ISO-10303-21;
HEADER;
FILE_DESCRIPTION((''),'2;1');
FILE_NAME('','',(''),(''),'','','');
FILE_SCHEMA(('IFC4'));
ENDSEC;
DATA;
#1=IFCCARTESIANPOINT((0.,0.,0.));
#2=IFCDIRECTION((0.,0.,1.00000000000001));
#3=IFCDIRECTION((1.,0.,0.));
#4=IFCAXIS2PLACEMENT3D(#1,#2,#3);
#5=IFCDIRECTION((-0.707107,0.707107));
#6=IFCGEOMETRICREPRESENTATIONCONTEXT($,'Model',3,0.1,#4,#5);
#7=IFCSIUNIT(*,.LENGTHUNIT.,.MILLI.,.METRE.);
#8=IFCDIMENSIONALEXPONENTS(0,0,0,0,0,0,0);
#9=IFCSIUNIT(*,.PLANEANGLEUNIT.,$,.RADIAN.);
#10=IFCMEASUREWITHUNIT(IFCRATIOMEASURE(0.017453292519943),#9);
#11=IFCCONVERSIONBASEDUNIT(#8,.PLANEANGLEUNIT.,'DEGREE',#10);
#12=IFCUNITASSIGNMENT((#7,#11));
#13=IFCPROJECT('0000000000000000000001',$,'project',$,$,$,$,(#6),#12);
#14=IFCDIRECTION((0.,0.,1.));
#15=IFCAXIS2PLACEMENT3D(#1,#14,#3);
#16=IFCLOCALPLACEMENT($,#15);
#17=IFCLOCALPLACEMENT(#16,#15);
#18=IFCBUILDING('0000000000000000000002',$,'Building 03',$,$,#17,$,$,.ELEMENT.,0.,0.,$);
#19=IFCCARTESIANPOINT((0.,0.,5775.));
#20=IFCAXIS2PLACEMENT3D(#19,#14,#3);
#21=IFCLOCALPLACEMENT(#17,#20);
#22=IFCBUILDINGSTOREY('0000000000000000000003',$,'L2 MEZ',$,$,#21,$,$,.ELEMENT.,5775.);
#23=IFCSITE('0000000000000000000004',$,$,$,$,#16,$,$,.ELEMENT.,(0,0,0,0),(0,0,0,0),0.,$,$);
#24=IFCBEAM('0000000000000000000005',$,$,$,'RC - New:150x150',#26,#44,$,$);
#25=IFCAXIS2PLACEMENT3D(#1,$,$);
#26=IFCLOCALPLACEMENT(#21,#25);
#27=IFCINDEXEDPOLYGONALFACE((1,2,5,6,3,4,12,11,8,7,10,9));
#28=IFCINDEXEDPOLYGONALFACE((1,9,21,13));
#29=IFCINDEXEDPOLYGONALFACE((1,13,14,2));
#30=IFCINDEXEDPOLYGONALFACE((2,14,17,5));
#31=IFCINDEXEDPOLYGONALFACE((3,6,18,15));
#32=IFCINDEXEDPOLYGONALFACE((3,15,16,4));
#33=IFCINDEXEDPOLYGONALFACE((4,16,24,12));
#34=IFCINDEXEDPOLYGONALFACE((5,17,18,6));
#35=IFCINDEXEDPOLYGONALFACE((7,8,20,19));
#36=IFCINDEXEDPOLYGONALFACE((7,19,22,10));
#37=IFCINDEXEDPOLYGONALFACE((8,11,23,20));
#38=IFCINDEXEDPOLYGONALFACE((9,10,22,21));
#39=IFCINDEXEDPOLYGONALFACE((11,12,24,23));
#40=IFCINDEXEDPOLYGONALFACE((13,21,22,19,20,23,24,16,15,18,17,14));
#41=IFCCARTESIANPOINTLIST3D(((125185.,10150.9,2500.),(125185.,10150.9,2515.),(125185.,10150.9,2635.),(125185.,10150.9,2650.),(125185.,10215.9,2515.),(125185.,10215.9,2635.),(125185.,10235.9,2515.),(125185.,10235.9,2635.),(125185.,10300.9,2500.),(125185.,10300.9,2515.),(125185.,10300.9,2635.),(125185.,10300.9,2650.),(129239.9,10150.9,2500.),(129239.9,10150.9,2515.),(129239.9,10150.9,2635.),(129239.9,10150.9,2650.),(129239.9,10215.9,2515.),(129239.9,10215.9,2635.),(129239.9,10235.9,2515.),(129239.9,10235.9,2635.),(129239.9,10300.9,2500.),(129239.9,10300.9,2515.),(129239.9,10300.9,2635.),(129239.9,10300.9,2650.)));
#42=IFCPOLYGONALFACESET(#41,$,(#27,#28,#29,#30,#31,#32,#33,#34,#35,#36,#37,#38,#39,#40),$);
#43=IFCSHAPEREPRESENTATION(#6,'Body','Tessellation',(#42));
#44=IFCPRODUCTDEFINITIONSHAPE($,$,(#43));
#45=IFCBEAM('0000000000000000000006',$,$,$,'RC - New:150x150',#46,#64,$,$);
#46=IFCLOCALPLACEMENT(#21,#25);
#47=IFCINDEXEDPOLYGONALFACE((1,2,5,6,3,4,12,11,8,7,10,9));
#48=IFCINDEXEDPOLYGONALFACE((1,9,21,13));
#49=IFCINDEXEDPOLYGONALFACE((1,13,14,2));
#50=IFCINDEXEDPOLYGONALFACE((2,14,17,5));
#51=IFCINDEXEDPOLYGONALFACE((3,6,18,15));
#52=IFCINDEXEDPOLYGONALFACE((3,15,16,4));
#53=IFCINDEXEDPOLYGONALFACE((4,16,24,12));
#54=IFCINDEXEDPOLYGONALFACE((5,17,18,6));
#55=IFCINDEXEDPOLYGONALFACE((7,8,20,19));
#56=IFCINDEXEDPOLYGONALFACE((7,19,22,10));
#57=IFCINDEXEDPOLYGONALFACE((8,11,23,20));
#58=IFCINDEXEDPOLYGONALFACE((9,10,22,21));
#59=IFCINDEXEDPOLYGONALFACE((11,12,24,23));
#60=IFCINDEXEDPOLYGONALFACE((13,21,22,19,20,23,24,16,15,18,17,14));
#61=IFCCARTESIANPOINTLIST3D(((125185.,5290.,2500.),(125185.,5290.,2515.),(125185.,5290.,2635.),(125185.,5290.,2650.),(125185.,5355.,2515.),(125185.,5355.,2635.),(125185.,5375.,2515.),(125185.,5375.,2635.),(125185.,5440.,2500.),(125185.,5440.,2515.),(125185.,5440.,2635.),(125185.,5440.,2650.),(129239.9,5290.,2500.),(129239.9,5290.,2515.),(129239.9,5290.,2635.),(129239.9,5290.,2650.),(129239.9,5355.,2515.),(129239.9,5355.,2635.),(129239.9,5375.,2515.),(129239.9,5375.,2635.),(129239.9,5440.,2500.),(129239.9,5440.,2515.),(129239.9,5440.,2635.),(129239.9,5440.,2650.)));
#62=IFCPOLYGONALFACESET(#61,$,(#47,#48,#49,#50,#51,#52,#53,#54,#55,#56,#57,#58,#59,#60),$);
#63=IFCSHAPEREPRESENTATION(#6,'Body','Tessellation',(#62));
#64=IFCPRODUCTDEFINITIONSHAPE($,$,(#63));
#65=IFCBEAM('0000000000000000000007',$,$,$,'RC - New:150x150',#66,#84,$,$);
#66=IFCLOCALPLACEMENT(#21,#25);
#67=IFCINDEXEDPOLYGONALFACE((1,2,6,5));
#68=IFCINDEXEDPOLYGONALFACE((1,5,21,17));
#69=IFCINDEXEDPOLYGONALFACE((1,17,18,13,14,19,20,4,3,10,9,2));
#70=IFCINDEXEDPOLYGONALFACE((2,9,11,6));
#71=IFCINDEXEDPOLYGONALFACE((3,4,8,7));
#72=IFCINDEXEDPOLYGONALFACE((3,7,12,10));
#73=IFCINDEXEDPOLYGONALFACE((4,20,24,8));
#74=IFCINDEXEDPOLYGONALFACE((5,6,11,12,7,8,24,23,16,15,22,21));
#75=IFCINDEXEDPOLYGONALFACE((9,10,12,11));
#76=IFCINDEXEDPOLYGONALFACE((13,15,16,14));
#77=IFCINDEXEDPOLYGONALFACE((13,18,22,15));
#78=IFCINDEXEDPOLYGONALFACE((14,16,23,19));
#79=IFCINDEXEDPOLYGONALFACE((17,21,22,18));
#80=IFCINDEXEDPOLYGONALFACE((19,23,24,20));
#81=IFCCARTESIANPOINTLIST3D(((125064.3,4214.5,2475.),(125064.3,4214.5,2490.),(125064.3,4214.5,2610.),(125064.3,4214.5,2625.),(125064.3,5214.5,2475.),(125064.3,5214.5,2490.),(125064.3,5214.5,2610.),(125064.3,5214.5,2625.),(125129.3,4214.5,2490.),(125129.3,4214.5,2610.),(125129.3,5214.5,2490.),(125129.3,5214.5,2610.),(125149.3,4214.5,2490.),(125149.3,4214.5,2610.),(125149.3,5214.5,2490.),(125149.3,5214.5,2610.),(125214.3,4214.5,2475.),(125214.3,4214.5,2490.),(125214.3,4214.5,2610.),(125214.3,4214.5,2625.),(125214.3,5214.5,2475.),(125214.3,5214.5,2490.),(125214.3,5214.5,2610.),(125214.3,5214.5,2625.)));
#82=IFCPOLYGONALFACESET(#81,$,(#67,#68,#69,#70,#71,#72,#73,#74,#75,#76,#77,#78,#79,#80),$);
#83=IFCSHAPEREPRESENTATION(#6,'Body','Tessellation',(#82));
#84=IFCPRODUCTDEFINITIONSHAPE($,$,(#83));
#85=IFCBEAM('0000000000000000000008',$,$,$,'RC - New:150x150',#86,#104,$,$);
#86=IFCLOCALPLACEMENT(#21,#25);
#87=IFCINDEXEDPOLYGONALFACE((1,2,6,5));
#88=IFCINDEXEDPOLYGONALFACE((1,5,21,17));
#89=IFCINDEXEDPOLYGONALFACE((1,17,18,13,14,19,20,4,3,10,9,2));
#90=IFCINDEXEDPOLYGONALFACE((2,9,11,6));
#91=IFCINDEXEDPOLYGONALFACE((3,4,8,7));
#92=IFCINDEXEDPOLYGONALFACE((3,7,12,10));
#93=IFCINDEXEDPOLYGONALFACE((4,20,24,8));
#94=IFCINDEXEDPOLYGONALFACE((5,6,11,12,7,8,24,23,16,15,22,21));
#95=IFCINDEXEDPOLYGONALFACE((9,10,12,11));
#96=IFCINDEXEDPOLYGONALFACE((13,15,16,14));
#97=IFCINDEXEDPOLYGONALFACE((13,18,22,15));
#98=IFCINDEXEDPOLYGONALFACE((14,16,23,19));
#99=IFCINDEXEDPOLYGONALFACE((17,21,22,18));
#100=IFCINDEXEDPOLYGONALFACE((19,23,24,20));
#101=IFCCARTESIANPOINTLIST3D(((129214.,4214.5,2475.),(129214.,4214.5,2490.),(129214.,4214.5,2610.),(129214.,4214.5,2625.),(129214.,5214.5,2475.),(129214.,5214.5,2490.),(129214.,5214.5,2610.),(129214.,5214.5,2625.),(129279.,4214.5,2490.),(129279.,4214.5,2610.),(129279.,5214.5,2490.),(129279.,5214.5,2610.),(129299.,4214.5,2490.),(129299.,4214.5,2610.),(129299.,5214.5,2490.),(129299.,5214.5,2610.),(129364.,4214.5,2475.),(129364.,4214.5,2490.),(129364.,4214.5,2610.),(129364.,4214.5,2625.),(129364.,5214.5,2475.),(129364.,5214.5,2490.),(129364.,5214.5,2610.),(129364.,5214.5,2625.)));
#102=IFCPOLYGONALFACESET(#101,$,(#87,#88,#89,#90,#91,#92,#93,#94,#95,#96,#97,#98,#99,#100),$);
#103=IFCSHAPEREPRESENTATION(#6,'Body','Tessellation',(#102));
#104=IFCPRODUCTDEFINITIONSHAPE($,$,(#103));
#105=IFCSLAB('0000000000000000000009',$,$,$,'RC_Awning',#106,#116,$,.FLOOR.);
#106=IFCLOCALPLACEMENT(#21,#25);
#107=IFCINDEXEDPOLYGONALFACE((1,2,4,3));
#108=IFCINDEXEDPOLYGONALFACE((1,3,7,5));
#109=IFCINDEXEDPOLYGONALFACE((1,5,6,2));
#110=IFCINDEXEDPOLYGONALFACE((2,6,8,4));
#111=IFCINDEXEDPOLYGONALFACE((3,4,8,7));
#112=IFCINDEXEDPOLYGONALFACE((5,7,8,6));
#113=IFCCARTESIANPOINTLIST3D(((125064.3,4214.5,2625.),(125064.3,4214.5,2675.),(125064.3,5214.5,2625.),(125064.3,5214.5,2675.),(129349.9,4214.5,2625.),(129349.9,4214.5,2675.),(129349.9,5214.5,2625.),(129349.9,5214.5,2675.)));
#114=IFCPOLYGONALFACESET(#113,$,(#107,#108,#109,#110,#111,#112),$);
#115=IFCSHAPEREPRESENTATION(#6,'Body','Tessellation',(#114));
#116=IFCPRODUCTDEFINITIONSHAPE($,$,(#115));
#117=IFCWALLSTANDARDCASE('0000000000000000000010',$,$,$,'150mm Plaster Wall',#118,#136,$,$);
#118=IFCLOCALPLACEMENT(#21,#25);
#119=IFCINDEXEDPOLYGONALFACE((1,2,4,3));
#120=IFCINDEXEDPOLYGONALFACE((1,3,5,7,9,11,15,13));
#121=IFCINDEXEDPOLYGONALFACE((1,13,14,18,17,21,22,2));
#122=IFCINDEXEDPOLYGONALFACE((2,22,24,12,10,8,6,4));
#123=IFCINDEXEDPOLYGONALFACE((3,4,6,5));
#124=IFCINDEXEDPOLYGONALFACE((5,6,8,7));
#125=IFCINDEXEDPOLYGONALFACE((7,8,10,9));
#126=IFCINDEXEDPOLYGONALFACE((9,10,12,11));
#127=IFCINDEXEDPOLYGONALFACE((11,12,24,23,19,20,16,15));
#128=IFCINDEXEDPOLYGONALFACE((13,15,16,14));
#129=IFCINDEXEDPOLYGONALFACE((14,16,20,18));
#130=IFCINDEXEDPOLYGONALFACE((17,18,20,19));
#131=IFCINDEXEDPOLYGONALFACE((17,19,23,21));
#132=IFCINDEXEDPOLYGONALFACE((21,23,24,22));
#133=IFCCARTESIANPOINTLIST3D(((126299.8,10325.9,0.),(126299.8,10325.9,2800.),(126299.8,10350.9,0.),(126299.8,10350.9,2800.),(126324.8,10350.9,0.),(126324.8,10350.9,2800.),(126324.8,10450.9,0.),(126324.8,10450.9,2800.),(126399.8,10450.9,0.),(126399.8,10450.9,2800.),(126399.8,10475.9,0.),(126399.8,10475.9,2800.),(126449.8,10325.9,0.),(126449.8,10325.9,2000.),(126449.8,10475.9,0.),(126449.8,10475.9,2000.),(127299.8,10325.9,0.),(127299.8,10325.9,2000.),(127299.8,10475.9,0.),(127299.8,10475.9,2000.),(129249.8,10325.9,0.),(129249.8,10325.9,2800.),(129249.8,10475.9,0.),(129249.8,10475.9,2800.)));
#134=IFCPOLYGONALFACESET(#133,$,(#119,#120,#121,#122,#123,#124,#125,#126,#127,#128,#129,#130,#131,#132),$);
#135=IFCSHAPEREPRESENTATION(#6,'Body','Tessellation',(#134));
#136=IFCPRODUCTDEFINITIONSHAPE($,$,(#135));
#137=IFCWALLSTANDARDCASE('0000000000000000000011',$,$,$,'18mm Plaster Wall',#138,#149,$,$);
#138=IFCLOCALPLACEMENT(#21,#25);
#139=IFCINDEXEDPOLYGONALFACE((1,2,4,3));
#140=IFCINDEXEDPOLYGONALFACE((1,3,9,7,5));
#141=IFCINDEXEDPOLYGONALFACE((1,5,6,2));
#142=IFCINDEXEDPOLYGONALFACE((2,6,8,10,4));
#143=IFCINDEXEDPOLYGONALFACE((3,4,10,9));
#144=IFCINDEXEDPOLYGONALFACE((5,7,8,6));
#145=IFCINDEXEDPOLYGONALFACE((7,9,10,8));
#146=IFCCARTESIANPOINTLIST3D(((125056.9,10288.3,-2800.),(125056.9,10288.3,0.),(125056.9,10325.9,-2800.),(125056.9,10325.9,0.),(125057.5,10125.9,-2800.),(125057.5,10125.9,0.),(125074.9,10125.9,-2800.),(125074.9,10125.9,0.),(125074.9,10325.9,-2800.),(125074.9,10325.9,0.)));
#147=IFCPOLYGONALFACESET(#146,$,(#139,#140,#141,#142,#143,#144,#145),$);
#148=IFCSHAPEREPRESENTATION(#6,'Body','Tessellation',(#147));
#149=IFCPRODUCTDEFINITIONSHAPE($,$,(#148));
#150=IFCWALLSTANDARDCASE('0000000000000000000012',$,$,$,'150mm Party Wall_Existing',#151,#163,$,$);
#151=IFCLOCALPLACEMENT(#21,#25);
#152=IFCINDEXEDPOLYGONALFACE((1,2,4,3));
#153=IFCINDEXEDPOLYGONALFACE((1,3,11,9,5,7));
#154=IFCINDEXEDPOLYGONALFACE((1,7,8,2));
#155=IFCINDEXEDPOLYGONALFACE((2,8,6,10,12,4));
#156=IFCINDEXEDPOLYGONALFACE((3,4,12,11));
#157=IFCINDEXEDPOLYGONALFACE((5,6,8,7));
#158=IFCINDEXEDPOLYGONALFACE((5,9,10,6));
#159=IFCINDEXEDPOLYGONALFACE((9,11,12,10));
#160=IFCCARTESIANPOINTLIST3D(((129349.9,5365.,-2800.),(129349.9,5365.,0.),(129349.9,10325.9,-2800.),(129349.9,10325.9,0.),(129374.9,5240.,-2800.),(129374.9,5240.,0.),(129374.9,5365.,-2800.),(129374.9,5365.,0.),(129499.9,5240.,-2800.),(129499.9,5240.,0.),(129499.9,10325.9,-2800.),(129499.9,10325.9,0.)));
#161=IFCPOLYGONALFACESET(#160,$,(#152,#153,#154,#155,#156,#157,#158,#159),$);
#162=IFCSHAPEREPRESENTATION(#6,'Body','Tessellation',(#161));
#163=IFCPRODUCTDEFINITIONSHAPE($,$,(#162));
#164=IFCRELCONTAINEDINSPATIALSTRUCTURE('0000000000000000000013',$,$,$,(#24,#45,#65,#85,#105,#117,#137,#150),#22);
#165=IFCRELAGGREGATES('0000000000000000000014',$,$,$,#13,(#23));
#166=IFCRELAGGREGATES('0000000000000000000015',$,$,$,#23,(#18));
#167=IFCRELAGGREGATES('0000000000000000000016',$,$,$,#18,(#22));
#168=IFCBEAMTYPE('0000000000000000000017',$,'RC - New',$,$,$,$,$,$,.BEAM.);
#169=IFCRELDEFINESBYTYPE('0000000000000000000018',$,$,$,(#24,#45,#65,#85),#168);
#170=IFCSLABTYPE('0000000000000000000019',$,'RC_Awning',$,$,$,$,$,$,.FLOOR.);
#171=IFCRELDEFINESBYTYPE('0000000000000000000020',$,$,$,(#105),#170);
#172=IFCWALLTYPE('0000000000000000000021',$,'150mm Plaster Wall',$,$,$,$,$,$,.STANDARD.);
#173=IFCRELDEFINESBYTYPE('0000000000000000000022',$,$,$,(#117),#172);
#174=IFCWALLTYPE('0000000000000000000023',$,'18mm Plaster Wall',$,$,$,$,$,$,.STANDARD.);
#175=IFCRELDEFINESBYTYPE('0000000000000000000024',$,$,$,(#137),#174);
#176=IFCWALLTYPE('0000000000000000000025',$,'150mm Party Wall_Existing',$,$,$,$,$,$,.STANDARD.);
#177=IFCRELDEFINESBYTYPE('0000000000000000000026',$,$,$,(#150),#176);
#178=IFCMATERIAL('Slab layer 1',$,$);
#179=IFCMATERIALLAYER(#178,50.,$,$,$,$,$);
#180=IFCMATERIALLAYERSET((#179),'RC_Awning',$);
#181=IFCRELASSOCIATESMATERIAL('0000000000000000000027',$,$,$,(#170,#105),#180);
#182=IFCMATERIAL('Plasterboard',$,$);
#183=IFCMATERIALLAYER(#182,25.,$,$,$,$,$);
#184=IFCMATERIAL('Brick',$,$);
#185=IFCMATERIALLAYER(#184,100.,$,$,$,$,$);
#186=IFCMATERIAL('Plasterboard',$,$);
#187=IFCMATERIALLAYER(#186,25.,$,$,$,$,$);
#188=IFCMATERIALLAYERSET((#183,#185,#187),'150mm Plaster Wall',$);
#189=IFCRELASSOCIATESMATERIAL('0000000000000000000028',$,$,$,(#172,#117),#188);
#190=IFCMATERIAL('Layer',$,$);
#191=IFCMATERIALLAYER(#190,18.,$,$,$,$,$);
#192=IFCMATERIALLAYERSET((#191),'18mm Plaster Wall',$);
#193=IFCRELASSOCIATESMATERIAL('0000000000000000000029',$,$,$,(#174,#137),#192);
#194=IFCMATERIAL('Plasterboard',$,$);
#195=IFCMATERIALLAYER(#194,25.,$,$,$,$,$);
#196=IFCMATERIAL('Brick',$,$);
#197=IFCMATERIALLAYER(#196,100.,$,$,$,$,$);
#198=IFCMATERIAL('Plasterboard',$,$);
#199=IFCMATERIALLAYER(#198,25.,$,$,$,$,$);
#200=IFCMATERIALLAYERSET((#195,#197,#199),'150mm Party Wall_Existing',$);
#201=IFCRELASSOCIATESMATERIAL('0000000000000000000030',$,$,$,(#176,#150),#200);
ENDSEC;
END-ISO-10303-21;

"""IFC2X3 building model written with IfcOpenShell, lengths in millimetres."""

from ifc_helpers import new_model, entity, si_unit, converted_unit, direction, frame, origin_with_axes, origin_2d, place, context, project, spatial, polyline, rectangle, i_section, outline, extrude, material, layer, layer_set, layer_usage, type_object, element, save


model = new_model("IFC2X3")

# Units and contexts
model_context = context("Model", 3, precision=0.1, world=frame((0.0, 0.0, 0.0), z_axis=(0.0, 0.0, 1.00000000000001), x_axis=(1.0, 0.0, 0.0)), true_north=direction((-0.707107, 0.707107)))
ifc_project = project(units=[si_unit("LENGTHUNIT", "METRE", prefix="MILLI"), converted_unit("PLANEANGLEUNIT", "DEGREE", entity("IfcRatioMeasure", 0.017453292519943), si_unit("PLANEANGLEUNIT", "RADIAN"), dimensions=[0, 0, 0, 0, 0, 0, 0])], contexts=[model_context])

# Site, building, storey
site_placement = place(None, origin_with_axes())
site = spatial("IfcSite", under=ifc_project, at=site_placement, CompositionType="ELEMENT", RefLatitude=(0, 0, 0, 0), RefLongitude=(0, 0, 0, 0), RefElevation=0.0)
building_placement = place(site_placement, origin_with_axes())
building = spatial("IfcBuilding", under=site, at=building_placement, Name="Building 03", CompositionType="ELEMENT", ElevationOfRefHeight=0.0, ElevationOfTerrain=0.0)
storey_placement = place(building_placement, frame((0.0, 0.0, 5775.0), z_axis=(0.0, 0.0, 1.0), x_axis=(1.0, 0.0, 0.0)))
storey = spatial("IfcBuildingStorey", under=building, at=storey_placement, Name="L2 MEZ", CompositionType="ELEMENT", Elevation=5775.0)

# Beams
beam_type = type_object("IfcBeamType", Name="RC - New", PredefinedType="BEAM")
for number, where, z_axis, x_axis in (
    (1, (125185.0, 10225.9, 8350.0), (1.0, 0.0, 0.0), (0.0, 1.0, 0.0)),
    (2, (125185.0, 5365.0, 8350.0), (1.0, 0.0, 0.0), (0.0, 1.0, 0.0)),
):
    element("IfcBeam", number, at=place(site_placement, frame(where, z_axis=z_axis, x_axis=x_axis)), inside=storey, type_object=beam_type, ObjectType="RC - New:150x150", context=model_context, shape_type="SweptSolid", body=[
        extrude(i_section(OverallWidth=150.0, OverallDepth=150.0, WebThickness=20.0, FlangeThickness=15.0, at=origin_2d()), frame((0.0, 0.0, 0.0), z_axis=(0.0, 0.0, 1.0), x_axis=(1.0, 0.0, 0.0)), (0.0, 0.0, 1.0), 4054.9),
    ])
beam_1_placement = place(site_placement, frame((125139.3, 4214.5, 8325.0), z_axis=(0.0, 1.0, 0.0), x_axis=(-1.0, 0.0, 0.0)))
element("IfcBeam", 3, at=beam_1_placement, inside=storey, type_object=beam_type, ObjectType="RC - New:150x150", context=model_context, shape_type="SweptSolid", body=[
    extrude(i_section(OverallWidth=150.0, OverallDepth=150.0, WebThickness=20.0, FlangeThickness=15.0, at=origin_2d()), origin_with_axes(), (0.0, 0.0, 1.0), 1000.0),
])
beam_2_placement = place(site_placement, frame((129289.0, 4214.5, 8325.0), z_axis=(0.0, 1.0, 0.0), x_axis=(-1.0, 0.0, 0.0)))
element("IfcBeam", 4, at=beam_2_placement, inside=storey, type_object=beam_type, ObjectType="RC - New:150x150", context=model_context, shape_type="SweptSolid", body=[
    extrude(outline(polyline([(-75.0, 75.0), (75.0, 75.0), (75.0, 60.0), (10.0, 60.0), (10.0, -60.0), (75.0, -60.0), (75.0, -75.0), (-75.0, -75.0), (-75.0, -60.0), (-10.0, -60.0), (-10.0, 60.0), (-75.0, 60.0), (-75.0, 75.0)])), frame((0.0, 0.0, 0.0), z_axis=(0.0, 0.0, 1.0), x_axis=(-1.0, 0.0, 0.0)), (0.0, 0.0, 1.0), 1000.0),
])

# Slab
ifc_material_1 = material(Name="Slab layer 1")
ifc_layer_1 = layer(ifc_material_1, 50.0)
ifc_layer_set_1 = layer_set([ifc_layer_1], Name="RC_Awning")
ifc_layer_usage_1 = layer_usage(ifc_layer_set_1, "AXIS3", "POSITIVE", 0.0)
slab_type_1 = type_object("IfcSlabType", Name="RC_Awning", PredefinedType="FLOOR", material=ifc_layer_set_1)
slab_1_placement = place(site_placement, frame((129349.9, 5214.5, 8400.0), z_axis=(0.0, 0.0, 1.0), x_axis=(-1.0, 0.0, 0.0)))
element("IfcSlab", 5, at=slab_1_placement, inside=storey, type_object=slab_type_1, material=ifc_layer_usage_1, ObjectType="RC_Awning", PredefinedType="FLOOR", context=model_context, shape_type="SweptSolid", body=[
    extrude(outline(polyline([(0.0, 0.0), (0.0, 1000.0), (4285.6, 1000.0), (4285.6, 0.0), (0.0, 0.0)])), origin_with_axes(), (0.0, 0.0, 1.0), 50.0),
])

# Wall, opening
ifc_material_2 = material(Name="Plasterboard")
ifc_layer_2 = layer(ifc_material_2, 25.0)
ifc_material_3 = material(Name="Brick")
ifc_layer_3 = layer(ifc_material_3, 100.0)
ifc_material_4 = material(Name="Plasterboard")
ifc_layer_4 = layer(ifc_material_4, 25.0)
ifc_layer_set_2 = layer_set([ifc_layer_2, ifc_layer_3, ifc_layer_4], Name="150mm Plaster Wall")
ifc_layer_usage_2 = layer_usage(ifc_layer_set_2, "AXIS2", "POSITIVE", -75.0)
wall_type_1 = type_object("IfcWallType", Name="150mm Plaster Wall", PredefinedType="STANDARD", material=ifc_layer_set_2)
wall_1_placement = place(site_placement, frame((126424.8, 10400.9, 5775.0), z_axis=(0.0, 0.0, 1.0), x_axis=(1.0, 0.0, 0.0)))
wall_1 = element("IfcWallStandardCase", 6, at=wall_1_placement, inside=storey, type_object=wall_type_1, material=ifc_layer_usage_2, ObjectType="150mm Plaster Wall", context=model_context, shape_type="SweptSolid", body=[
    extrude(outline(polyline([(2825.0, 75.0), (2825.0, -75.0), (-125.0, -75.0), (-125.0, -50.0), (-100.0, -50.0), (-100.0, 50.0), (-25.0, 50.0), (-25.0, 75.0), (2825.0, 75.0)])), origin_with_axes(), (0.0, 0.0, 1.0), 2800.0),
])
opening_1_placement = place(wall_1_placement, frame((450.0, 0.0, 0.0), z_axis=(0.0, 0.0, 1.0), x_axis=(1.0, 0.0, 0.0)))
element("IfcOpeningElement", 7, at=opening_1_placement, cuts=wall_1, ObjectType="Opening", context=model_context, shape_type="SweptSolid", body=[
    extrude(rectangle(XDim=850.0, YDim=2000.0, at=origin_2d()), frame((0.0, 750.0, 1000.0), z_axis=(0.0, -1.0, 0.0), x_axis=(1.0, 0.0, 0.0)), (0.0, 0.0, 1.0), 1500.0),
])

# Walls
ifc_material_5 = material(Name="Layer")
ifc_layer_5 = layer(ifc_material_5, 18.0)
ifc_layer_set_3 = layer_set([ifc_layer_5], Name="18mm Plaster Wall")
ifc_layer_usage_3 = layer_usage(ifc_layer_set_3, "AXIS2", "POSITIVE", -9.0)
wall_type_2 = type_object("IfcWallType", Name="18mm Plaster Wall", PredefinedType="STANDARD", material=ifc_layer_set_3)
wall_2_placement = place(site_placement, frame((125065.9, 10325.9, 2975.0), z_axis=(0.0, 0.0, 1.0), x_axis=(0.0, -1.0, 0.0)))
element("IfcWallStandardCase", 8, at=wall_2_placement, inside=storey, type_object=wall_type_2, material=ifc_layer_usage_3, ObjectType="18mm Plaster Wall", context=model_context, shape_type="SweptSolid", body=[
    extrude(outline(polyline([(200.0, -8.4), (37.6, -9.0), (0.0, -9.0), (0.0, 9.0), (200.0, 9.0), (200.0, -8.4)])), origin_with_axes(), (0.0, 0.0, 1.0), 2800.0),
])
ifc_material_6 = material(Name="Plasterboard")
ifc_layer_6 = layer(ifc_material_6, 25.0)
ifc_material_7 = material(Name="Brick")
ifc_layer_7 = layer(ifc_material_7, 100.0)
ifc_material_8 = material(Name="Plasterboard")
ifc_layer_8 = layer(ifc_material_8, 25.0)
ifc_layer_set_4 = layer_set([ifc_layer_6, ifc_layer_7, ifc_layer_8], Name="150mm Party Wall_Existing")
ifc_layer_usage_4 = layer_usage(ifc_layer_set_4, "AXIS2", "POSITIVE", -75.0)
wall_type_3 = type_object("IfcWallType", Name="150mm Party Wall_Existing", PredefinedType="STANDARD", material=ifc_layer_set_4)
wall_3_placement = place(site_placement, frame((129424.9, 10325.9, 2975.0), z_axis=(0.0, 0.0, 1.0), x_axis=(0.0, -1.0, 0.0)))
element("IfcWallStandardCase", 9, at=wall_3_placement, inside=storey, type_object=wall_type_3, material=ifc_layer_usage_4, ObjectType="150mm Party Wall_Existing", context=model_context, shape_type="SweptSolid", body=[
    extrude(outline(polyline([(5085.9, 75.0), (5085.9, -50.0), (4960.9, -50.0), (4960.9, -75.0), (0.0, -75.0), (0.0, 75.0), (5085.9, 75.0)])), origin_with_axes(), (0.0, 0.0, 1.0), 2800.0),
])

save(model, "model.ifc")
